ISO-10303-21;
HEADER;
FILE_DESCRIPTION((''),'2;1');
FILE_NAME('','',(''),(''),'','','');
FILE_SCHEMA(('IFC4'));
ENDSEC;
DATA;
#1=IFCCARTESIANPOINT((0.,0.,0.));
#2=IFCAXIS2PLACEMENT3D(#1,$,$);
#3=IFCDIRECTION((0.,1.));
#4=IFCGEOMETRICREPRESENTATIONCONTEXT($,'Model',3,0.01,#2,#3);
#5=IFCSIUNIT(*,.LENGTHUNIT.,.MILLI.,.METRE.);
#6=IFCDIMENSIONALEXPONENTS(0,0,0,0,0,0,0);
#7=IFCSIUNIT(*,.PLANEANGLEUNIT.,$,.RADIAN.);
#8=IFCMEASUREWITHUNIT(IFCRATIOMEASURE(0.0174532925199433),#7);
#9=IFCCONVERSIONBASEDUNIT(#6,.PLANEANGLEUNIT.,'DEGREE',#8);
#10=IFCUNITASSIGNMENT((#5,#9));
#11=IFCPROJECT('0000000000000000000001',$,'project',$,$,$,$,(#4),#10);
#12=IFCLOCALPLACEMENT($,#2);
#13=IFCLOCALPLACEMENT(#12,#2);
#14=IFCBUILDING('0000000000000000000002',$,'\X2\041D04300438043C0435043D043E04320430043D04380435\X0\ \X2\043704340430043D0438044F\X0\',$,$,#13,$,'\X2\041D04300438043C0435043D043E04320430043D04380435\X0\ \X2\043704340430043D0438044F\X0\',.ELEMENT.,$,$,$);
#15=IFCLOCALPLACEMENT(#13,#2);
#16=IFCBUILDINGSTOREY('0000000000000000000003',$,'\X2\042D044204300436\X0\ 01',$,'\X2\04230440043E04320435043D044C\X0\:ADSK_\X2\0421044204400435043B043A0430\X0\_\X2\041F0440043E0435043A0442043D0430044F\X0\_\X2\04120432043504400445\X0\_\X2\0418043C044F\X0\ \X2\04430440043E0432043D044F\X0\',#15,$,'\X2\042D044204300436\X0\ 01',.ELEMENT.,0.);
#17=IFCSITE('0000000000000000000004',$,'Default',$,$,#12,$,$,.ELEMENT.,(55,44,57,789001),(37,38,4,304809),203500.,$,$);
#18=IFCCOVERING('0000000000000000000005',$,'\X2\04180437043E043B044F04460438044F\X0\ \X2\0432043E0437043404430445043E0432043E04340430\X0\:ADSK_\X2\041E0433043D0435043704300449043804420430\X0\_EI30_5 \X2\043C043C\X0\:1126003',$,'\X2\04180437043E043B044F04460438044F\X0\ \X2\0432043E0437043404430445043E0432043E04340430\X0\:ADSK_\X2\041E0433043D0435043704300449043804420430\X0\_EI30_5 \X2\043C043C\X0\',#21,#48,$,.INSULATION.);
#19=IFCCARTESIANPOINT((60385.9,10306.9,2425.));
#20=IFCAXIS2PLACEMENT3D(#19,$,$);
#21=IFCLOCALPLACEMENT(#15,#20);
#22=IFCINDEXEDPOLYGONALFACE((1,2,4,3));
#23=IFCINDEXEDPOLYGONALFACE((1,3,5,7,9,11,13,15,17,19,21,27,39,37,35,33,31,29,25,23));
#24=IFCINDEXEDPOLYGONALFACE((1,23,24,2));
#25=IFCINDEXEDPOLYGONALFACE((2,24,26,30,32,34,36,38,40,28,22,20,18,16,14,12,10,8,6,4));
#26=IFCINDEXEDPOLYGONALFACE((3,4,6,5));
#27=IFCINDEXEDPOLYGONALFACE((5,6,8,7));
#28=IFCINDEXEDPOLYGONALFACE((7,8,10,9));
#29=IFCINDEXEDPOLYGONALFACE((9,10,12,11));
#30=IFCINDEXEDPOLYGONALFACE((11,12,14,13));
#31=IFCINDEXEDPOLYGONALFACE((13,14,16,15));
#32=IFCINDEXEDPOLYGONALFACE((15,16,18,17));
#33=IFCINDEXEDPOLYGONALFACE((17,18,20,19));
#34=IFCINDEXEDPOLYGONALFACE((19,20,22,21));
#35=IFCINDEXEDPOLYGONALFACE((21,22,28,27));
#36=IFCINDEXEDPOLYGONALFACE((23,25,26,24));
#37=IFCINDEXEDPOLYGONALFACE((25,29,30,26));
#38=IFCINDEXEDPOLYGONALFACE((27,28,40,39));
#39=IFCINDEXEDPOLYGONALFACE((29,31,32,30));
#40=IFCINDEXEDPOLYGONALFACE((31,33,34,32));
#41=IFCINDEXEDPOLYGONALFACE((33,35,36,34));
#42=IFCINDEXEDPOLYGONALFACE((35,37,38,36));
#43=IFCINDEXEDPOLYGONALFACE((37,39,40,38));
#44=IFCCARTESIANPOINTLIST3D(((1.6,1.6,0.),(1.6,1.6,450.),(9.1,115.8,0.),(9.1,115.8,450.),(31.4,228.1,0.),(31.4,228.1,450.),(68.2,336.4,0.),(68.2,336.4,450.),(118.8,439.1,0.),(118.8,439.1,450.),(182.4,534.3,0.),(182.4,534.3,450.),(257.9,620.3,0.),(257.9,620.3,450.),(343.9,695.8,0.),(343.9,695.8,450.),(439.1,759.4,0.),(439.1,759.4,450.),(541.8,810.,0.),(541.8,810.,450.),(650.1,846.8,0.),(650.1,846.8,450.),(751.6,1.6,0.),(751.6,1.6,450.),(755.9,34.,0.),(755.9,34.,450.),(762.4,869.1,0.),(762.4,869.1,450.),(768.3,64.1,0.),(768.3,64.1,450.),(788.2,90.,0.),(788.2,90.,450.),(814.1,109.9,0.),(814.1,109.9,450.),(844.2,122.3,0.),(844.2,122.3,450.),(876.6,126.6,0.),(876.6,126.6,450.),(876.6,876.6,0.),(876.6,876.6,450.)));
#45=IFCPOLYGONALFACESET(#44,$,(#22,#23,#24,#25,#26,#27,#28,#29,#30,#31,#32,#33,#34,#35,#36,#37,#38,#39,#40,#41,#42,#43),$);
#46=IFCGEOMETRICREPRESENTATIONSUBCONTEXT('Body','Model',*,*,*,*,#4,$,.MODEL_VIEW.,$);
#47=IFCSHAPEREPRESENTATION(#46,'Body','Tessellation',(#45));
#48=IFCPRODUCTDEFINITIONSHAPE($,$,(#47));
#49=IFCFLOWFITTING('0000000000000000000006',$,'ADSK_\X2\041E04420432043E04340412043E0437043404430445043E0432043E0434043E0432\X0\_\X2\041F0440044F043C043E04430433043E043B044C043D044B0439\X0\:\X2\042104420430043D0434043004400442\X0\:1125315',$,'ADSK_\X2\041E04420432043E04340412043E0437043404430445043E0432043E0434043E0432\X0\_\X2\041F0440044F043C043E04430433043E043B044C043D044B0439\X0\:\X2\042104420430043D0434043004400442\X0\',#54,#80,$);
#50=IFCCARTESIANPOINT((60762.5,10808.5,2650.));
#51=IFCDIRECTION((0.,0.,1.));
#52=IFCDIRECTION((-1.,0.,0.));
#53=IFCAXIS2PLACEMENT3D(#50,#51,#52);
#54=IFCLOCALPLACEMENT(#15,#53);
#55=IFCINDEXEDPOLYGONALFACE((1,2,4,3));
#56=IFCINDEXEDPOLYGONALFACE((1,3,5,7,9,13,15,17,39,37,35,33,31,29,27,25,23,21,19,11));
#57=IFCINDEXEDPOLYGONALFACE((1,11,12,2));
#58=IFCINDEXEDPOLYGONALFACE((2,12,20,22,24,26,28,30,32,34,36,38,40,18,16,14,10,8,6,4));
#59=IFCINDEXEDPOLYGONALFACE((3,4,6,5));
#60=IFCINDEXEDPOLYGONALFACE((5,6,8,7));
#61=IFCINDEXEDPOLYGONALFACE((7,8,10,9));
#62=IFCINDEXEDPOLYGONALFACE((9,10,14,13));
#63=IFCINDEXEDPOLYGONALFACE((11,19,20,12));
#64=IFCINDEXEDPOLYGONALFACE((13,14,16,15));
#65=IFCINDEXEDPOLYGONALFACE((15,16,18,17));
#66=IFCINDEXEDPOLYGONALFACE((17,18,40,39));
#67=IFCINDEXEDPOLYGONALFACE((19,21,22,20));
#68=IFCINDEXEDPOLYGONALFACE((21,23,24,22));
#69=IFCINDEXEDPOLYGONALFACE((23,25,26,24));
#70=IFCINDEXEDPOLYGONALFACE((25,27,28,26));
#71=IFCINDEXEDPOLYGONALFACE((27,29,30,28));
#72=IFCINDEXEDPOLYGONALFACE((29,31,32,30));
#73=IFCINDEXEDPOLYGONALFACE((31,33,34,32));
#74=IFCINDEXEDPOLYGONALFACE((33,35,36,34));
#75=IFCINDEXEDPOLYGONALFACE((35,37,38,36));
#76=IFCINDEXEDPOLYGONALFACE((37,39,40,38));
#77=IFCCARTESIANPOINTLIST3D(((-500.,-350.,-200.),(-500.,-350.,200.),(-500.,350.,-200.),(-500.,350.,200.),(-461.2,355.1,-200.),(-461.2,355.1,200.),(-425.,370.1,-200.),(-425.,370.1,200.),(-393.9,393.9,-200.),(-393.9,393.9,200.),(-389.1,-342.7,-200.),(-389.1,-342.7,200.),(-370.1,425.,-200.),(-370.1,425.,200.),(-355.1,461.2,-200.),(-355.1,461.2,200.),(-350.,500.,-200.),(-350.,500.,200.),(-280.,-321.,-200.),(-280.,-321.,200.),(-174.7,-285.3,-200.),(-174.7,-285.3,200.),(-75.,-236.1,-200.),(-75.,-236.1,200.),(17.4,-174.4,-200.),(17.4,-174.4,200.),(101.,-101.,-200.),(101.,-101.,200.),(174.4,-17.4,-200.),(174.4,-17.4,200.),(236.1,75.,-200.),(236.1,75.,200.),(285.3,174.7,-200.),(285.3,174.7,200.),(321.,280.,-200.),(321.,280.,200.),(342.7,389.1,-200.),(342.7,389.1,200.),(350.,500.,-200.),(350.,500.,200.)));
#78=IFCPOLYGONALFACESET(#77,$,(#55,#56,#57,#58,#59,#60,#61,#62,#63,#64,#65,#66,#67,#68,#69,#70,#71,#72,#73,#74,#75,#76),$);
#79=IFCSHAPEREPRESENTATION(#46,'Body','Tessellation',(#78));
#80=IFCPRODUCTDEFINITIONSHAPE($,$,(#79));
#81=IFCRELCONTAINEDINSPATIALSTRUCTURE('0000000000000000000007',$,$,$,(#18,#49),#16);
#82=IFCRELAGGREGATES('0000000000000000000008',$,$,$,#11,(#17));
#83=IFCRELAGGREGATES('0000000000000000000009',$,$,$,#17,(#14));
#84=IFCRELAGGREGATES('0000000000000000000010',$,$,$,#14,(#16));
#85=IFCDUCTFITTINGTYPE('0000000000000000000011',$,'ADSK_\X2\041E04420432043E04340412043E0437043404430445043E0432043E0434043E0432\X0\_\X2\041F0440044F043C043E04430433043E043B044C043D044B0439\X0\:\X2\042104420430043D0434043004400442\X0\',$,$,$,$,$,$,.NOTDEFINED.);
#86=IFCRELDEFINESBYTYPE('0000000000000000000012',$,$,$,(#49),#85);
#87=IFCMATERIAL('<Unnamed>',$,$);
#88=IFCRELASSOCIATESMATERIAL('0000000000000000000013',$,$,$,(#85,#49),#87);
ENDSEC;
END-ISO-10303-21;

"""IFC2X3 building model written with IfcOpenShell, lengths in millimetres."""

from ifc_helpers import new_model, entity, si_unit, converted_unit, direction, frame, frame_2d, origin, place, context, subcontext, project, spatial, polyline, circle_curve, parameter, trimmed, segment, composite_curve, outline, extrude, source, transform, mapped, material, type_object, type_shapes, element, save


model = new_model("IFC2X3")

# Units and contexts
model_context = context("Model", 3, precision=0.01, world=origin(), true_north=direction((0.0, 1.0)))
body_context = subcontext(model_context, "Body", "Model", "MODEL_VIEW")
ifc_project = project(units=[si_unit("LENGTHUNIT", "METRE", prefix="MILLI"), converted_unit("PLANEANGLEUNIT", "DEGREE", entity("IfcRatioMeasure", 0.0174532925199433), si_unit("PLANEANGLEUNIT", "RADIAN"), dimensions=[0, 0, 0, 0, 0, 0, 0])], contexts=[model_context])

# Site, building, storey
site_placement = place(None, origin())
site = spatial("IfcSite", under=ifc_project, at=site_placement, Name="Default", CompositionType="ELEMENT", RefLatitude=(55, 44, 57, 789001), RefLongitude=(37, 38, 4, 304809), RefElevation=203500.0)
building_placement = place(site_placement, origin())
building = spatial("IfcBuilding", under=site, at=building_placement, Name="Наименование здания", LongName="Наименование здания", CompositionType="ELEMENT")
storey_placement = place(building_placement, origin())
storey = spatial("IfcBuildingStorey", under=building, at=storey_placement, Name="Этаж 01", ObjectType="Уровень:ADSK_Стрелка_Проектная_Вверх_Имя уровня", LongName="Этаж 01", CompositionType="ELEMENT", Elevation=0.0)

# Covering
covering_1_placement = place(storey_placement, frame((60385.9, 10306.9, 2425.0)))
element("IfcCovering", 1, at=covering_1_placement, inside=storey, Name="Изоляция воздуховода:ADSK_Огнезащита_EI30_5 мм:1126003", ObjectType="Изоляция воздуховода:ADSK_Огнезащита_EI30_5 мм", PredefinedType="INSULATION", context=body_context, shape_type="SweptSolid", body=[
    extrude(outline(composite_curve([segment(polyline([(-250.0, 125.0), (-250.0, -625.0)]), True, "CONTINUOUS"), segment(trimmed(circle_curve(frame_2d((-250.0, 250.0), x_axis=(1.0, 0.0)), 875.0), [parameter(270.0)], [parameter(0.0)], True, "PARAMETER"), True, "CONTINUOUS"), segment(polyline([(625.0, 250.0), (-125.0, 250.0)]), True, "CONTINUOUS"), segment(trimmed(circle_curve(frame_2d((-250.0, 250.0), x_axis=(1.0, 0.0)), 125.0), [parameter(270.0)], [parameter(360.0)], True, "PARAMETER"), False, "CONTINUOUS")], self_intersect=False)), frame((626.6, 251.6, 0.0), z_axis=(0.0, 0.0, -1.0), x_axis=(0.0, 1.0, 0.0)), (0.0, 0.0, -1.0), 450.0),
])

# Shared definitions
ifc_material_1 = material(Name="<Unnamed>")

# Flow fitting
duct_fitting_type_1 = type_object("IfcDuctFittingType", Name="ADSK_ОтводВоздуховодов_Прямоугольный:Стандарт", PredefinedType="NOTDEFINED", material=ifc_material_1)
shared_shape_1 = source(origin(), body_context, "Body", "SweptSolid", [
    extrude(outline(composite_curve([segment(polyline([(-600.0, -250.0), (100.0, -250.0)]), True, "CONTINUOUS"), segment(trimmed(circle_curve(frame_2d((250.0, -250.0), x_axis=(0.0, 1.0)), 150.0), [parameter(0.0)], [parameter(90.0)], True, "PARAMETER"), False, "CONTINUOUS"), segment(polyline([(250.0, -100.0), (250.0, 600.0)]), True, "CONTINUOUS"), segment(trimmed(circle_curve(frame_2d((250.0, -250.0), x_axis=(0.0, 1.0)), 850.0), [parameter(0.0)], [parameter(90.0)], True, "PARAMETER"), True, "CONTINUOUS")], self_intersect=False)), frame((-250.0, 250.0, -200.0), z_axis=(0.0, 0.0, 1.0), x_axis=(-1.0, 0.0, 0.0)), (0.0, 0.0, 1.0), 400.0),
])
type_shapes(duct_fitting_type_1, [shared_shape_1])
flow_fitting_1_placement = place(storey_placement, frame((60762.5, 10808.5, 2650.0), z_axis=(0.0, 0.0, 1.0), x_axis=(-1.0, 0.0, 0.0)))
element("IfcFlowFitting", 2, at=flow_fitting_1_placement, inside=storey, type_object=duct_fitting_type_1, material=ifc_material_1, Name="ADSK_ОтводВоздуховодов_Прямоугольный:Стандарт:1125315", ObjectType="ADSK_ОтводВоздуховодов_Прямоугольный:Стандарт", context=body_context, shape_type="MappedRepresentation", body=[
    mapped(shared_shape_1, transform((0.0, 0.0, 0.0), scale=1.0)),
])

save(model, "model.ifc")
